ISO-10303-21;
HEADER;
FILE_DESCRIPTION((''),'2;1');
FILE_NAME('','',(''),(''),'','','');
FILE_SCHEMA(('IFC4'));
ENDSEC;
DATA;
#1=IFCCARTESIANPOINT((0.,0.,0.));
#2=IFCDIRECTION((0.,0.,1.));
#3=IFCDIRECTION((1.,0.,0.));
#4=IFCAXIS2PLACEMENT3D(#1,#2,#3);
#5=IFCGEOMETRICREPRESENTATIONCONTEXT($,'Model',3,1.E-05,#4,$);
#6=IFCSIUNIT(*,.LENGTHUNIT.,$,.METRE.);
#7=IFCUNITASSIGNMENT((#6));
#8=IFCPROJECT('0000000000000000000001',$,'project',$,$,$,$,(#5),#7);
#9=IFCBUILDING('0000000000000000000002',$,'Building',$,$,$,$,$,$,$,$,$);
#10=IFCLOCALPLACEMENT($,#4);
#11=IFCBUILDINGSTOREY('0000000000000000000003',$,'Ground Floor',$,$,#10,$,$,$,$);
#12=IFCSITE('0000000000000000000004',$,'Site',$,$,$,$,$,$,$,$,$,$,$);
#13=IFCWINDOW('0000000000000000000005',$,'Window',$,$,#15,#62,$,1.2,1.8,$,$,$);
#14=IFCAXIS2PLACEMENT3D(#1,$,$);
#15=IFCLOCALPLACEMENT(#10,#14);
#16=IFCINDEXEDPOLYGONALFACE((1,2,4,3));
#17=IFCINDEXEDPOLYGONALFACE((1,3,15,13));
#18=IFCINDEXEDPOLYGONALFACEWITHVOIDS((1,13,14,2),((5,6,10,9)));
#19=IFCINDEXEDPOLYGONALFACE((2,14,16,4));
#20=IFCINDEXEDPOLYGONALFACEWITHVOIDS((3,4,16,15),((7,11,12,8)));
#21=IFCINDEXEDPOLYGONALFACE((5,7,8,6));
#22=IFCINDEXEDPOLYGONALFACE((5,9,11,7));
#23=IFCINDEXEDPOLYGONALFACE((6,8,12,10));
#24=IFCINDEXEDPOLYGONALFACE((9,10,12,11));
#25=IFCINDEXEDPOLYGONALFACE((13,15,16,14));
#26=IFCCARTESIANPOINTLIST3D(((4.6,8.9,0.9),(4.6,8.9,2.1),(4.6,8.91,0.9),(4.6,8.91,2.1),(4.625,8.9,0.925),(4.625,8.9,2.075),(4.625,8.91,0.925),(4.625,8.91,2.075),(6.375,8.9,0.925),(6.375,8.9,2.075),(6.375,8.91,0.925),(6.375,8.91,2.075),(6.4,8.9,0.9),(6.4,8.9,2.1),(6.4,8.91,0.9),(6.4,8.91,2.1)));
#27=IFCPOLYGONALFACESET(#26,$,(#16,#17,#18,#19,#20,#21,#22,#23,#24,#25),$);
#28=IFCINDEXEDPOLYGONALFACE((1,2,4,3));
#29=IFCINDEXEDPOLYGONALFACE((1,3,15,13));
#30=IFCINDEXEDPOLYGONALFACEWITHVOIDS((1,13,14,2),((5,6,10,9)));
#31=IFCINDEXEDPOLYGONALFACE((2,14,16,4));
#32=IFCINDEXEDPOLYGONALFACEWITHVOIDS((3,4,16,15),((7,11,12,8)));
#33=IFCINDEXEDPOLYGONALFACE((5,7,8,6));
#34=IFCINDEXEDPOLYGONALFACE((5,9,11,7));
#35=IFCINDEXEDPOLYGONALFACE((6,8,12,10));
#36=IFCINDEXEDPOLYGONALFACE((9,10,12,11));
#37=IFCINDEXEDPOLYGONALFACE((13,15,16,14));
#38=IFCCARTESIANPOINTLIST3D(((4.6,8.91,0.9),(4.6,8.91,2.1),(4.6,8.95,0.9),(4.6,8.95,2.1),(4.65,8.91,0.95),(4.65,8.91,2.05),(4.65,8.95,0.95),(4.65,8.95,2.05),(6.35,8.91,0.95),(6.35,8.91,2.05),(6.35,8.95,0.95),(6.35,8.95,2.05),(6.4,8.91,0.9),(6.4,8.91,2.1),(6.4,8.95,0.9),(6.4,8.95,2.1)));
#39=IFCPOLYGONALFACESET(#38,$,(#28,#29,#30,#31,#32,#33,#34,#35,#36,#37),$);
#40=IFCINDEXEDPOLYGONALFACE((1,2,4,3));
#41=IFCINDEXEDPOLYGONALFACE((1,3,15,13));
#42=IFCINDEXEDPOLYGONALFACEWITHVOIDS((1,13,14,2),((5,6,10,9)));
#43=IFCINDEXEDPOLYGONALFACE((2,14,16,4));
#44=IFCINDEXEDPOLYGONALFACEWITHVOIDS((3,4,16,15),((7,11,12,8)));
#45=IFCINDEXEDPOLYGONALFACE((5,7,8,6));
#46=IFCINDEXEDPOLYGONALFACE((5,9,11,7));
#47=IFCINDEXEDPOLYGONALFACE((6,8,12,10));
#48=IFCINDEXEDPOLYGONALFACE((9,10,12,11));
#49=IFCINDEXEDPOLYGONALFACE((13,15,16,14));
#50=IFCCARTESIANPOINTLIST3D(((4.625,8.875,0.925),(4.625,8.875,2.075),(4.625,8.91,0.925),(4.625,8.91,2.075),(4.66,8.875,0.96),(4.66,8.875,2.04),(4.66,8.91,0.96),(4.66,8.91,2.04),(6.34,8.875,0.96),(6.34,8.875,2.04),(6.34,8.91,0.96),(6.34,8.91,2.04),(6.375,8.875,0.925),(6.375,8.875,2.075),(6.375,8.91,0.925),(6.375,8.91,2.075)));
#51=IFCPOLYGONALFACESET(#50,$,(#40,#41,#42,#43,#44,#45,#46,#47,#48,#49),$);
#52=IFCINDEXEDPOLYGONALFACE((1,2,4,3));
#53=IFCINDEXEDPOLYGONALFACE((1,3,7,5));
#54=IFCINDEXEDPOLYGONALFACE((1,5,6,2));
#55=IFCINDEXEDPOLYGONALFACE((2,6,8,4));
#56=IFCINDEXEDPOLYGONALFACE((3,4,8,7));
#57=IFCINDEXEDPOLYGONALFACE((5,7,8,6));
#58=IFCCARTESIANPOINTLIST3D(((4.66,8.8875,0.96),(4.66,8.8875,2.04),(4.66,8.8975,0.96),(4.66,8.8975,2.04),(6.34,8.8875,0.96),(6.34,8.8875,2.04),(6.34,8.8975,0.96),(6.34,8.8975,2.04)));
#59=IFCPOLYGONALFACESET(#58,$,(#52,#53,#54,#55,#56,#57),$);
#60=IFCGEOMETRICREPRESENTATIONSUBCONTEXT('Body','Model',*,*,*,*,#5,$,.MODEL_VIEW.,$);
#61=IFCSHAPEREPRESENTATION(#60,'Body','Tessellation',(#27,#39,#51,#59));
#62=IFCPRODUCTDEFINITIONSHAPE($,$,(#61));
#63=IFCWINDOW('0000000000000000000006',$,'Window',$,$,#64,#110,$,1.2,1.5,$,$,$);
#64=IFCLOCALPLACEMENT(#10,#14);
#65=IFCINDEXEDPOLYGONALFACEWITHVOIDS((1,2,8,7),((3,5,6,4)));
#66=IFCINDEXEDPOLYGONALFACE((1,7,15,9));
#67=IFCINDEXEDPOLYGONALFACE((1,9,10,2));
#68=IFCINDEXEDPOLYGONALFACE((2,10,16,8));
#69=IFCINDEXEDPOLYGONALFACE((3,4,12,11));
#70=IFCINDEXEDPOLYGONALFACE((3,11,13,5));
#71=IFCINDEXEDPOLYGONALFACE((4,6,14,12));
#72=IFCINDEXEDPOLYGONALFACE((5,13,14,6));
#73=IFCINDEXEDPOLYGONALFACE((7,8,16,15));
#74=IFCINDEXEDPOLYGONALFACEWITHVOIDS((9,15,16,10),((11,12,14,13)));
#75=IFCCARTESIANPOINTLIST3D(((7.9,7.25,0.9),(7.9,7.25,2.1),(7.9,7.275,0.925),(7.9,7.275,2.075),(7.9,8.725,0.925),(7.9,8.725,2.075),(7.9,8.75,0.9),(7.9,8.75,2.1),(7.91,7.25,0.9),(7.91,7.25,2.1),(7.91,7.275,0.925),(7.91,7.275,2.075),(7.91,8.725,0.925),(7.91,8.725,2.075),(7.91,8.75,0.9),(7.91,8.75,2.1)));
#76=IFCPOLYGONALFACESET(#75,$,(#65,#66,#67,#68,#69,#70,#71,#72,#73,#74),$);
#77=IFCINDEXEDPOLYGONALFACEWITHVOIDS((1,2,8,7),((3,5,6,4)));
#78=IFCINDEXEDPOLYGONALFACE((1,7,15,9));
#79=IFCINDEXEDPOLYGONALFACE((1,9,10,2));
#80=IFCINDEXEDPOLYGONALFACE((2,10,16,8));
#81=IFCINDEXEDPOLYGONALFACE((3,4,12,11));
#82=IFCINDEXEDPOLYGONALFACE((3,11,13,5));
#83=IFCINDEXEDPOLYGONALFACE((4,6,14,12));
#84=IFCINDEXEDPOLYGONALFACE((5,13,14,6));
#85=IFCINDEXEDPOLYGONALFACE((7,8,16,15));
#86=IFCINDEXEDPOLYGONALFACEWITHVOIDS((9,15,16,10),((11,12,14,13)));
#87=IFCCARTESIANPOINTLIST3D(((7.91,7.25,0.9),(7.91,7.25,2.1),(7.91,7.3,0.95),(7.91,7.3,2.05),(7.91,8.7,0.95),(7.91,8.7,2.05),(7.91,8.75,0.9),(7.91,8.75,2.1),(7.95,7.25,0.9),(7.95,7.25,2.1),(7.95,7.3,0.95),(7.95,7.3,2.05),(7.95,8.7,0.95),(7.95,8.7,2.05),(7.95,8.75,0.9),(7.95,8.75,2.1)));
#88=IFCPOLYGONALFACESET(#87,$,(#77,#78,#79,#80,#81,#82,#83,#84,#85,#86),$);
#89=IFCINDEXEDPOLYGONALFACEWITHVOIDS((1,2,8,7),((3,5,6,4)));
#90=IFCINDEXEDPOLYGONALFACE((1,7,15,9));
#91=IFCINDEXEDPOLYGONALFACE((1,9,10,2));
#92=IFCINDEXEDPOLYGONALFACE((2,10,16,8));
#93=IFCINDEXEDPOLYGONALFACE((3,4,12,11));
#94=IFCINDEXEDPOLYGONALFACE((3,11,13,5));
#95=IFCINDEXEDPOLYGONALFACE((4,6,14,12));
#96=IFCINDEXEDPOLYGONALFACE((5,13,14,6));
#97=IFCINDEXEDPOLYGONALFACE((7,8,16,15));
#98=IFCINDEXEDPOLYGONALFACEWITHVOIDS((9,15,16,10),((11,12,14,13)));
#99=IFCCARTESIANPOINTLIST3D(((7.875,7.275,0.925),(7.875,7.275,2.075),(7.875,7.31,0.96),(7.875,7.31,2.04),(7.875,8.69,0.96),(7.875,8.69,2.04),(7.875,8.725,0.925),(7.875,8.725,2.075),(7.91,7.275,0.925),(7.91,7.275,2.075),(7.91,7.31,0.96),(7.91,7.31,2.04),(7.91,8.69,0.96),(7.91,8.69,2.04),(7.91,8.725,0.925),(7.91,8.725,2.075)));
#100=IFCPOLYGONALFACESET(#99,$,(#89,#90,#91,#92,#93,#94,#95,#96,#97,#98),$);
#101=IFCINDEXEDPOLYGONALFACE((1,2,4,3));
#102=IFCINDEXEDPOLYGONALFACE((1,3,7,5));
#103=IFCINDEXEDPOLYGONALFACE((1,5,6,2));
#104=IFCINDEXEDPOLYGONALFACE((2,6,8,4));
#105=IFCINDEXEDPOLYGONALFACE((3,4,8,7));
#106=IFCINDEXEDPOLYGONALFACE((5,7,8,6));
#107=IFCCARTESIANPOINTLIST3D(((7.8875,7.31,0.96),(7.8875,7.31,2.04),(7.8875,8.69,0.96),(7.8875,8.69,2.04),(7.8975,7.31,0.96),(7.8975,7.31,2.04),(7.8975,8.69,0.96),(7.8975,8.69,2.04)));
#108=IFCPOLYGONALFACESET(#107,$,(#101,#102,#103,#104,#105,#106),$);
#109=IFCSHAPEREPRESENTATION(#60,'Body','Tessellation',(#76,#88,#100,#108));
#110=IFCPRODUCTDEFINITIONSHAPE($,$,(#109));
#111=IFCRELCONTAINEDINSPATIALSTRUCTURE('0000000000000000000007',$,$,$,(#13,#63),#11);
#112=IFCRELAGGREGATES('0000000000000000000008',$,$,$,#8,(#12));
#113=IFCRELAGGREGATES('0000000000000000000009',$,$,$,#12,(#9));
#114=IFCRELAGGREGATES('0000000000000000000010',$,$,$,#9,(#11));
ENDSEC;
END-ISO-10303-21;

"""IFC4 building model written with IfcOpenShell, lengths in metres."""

from ifc_helpers import new_model, si_unit, frame, origin_with_axes, place, context, subcontext, project, spatial, line, indexed_curve, outline, extrude, element, save


model = new_model("IFC4")

# Units and contexts
model_context = context("Model", 3, precision=1e-05, world=origin_with_axes())
body_context = subcontext(model_context, "Body", "Model", "MODEL_VIEW")
ifc_project = project(units=[si_unit("LENGTHUNIT", "METRE")], contexts=[model_context])

# Site, building, storey
site = spatial("IfcSite", under=ifc_project, Name="Site")
building = spatial("IfcBuilding", under=site, Name="Building")
storey_placement = place(None, origin_with_axes())
storey = spatial("IfcBuildingStorey", under=building, at=storey_placement, Name="Ground Floor")

# Windows
window_1_placement = place(storey_placement, frame((6.4, 9.0, 0.9), z_axis=(0.0, 0.0, 1.0), x_axis=(-1.0, 0.0, 0.0)))
element("IfcWindow", 1, at=window_1_placement, inside=storey, Name="Window", OverallHeight=1.2, OverallWidth=1.8, context=body_context, shape_type="SweptSolid", body=[
    extrude(outline(indexed_curve([(0.0, 0.0), (1.8, 0.0), (1.8, 1.2), (0.0, 1.2)], segments=[line(1, 2, 3, 4, 1)]), holes=[indexed_curve([(0.025, 0.025), (1.775, 0.025), (1.775, 1.175), (0.025, 1.175)], segments=[line(1, 2, 3, 4, 1)])]), frame((0.0, 0.09, 0.0), z_axis=(0.0, -1.0, 0.0), x_axis=(1.0, 0.0, 0.0)), (0.0, 0.0, -1.0), 0.01),
    extrude(outline(indexed_curve([(0.0, 0.0), (1.8, 0.0), (1.8, 1.2), (0.0, 1.2)], segments=[line(1, 2, 3, 4, 1)]), holes=[indexed_curve([(0.05, 0.05), (1.75, 0.05), (1.75, 1.15), (0.05, 1.15)], segments=[line(1, 2, 3, 4, 1)])]), frame((0.0, 0.05, 0.0), z_axis=(0.0, -1.0, 0.0), x_axis=(1.0, 0.0, 0.0)), (0.0, 0.0, -1.0), 0.04),
    extrude(outline(indexed_curve([(0.0, 0.0), (1.75, 0.0), (1.75, 1.15), (0.0, 1.15)], segments=[line(1, 2, 3, 4, 1)]), holes=[indexed_curve([(0.035, 0.035), (1.715, 0.035), (1.715, 1.115), (0.035, 1.115)], segments=[line(1, 2, 3, 4, 1)])]), frame((0.025, 0.09, 0.025), z_axis=(0.0, -1.0, 0.0), x_axis=(1.0, 0.0, 0.0)), (0.0, 0.0, -1.0), 0.035),
    extrude(outline(indexed_curve([(0.035, 0.035), (1.715, 0.035), (1.715, 1.115), (0.035, 1.115)], segments=[line(1, 2, 3, 4, 1)])), frame((0.025, 0.1025, 0.025), z_axis=(0.0, -1.0, 0.0), x_axis=(1.0, 0.0, 0.0)), (0.0, 0.0, -1.0), 0.01),
])
window_2_placement = place(storey_placement, frame((8.0, 7.25, 0.9), z_axis=(0.0, 0.0, 1.0), x_axis=(0.0, 1.0, 0.0)))
element("IfcWindow", 2, at=window_2_placement, inside=storey, Name="Window", OverallHeight=1.2, OverallWidth=1.5, context=body_context, shape_type="SweptSolid", body=[
    extrude(outline(indexed_curve([(0.0, 0.0), (1.5, 0.0), (1.5, 1.2), (0.0, 1.2)], segments=[line(1, 2, 3, 4, 1)]), holes=[indexed_curve([(0.025, 0.025), (1.475, 0.025), (1.475, 1.175), (0.025, 1.175)], segments=[line(1, 2, 3, 4, 1)])]), frame((0.0, 0.09, 0.0), z_axis=(0.0, -1.0, 0.0), x_axis=(1.0, 0.0, 0.0)), (0.0, 0.0, -1.0), 0.01),
    extrude(outline(indexed_curve([(0.0, 0.0), (1.5, 0.0), (1.5, 1.2), (0.0, 1.2)], segments=[line(1, 2, 3, 4, 1)]), holes=[indexed_curve([(0.05, 0.05), (1.45, 0.05), (1.45, 1.15), (0.05, 1.15)], segments=[line(1, 2, 3, 4, 1)])]), frame((0.0, 0.05, 0.0), z_axis=(0.0, -1.0, 0.0), x_axis=(1.0, 0.0, 0.0)), (0.0, 0.0, -1.0), 0.04),
    extrude(outline(indexed_curve([(0.0, 0.0), (1.45, 0.0), (1.45, 1.15), (0.0, 1.15)], segments=[line(1, 2, 3, 4, 1)]), holes=[indexed_curve([(0.035, 0.035), (1.415, 0.035), (1.415, 1.115), (0.035, 1.115)], segments=[line(1, 2, 3, 4, 1)])]), frame((0.025, 0.09, 0.025), z_axis=(0.0, -1.0, 0.0), x_axis=(1.0, 0.0, 0.0)), (0.0, 0.0, -1.0), 0.035),
    extrude(outline(indexed_curve([(0.035, 0.035), (1.415, 0.035), (1.415, 1.115), (0.035, 1.115)], segments=[line(1, 2, 3, 4, 1)])), frame((0.025, 0.1025, 0.025), z_axis=(0.0, -1.0, 0.0), x_axis=(1.0, 0.0, 0.0)), (0.0, 0.0, -1.0), 0.01),
])

save(model, "model.ifc")
